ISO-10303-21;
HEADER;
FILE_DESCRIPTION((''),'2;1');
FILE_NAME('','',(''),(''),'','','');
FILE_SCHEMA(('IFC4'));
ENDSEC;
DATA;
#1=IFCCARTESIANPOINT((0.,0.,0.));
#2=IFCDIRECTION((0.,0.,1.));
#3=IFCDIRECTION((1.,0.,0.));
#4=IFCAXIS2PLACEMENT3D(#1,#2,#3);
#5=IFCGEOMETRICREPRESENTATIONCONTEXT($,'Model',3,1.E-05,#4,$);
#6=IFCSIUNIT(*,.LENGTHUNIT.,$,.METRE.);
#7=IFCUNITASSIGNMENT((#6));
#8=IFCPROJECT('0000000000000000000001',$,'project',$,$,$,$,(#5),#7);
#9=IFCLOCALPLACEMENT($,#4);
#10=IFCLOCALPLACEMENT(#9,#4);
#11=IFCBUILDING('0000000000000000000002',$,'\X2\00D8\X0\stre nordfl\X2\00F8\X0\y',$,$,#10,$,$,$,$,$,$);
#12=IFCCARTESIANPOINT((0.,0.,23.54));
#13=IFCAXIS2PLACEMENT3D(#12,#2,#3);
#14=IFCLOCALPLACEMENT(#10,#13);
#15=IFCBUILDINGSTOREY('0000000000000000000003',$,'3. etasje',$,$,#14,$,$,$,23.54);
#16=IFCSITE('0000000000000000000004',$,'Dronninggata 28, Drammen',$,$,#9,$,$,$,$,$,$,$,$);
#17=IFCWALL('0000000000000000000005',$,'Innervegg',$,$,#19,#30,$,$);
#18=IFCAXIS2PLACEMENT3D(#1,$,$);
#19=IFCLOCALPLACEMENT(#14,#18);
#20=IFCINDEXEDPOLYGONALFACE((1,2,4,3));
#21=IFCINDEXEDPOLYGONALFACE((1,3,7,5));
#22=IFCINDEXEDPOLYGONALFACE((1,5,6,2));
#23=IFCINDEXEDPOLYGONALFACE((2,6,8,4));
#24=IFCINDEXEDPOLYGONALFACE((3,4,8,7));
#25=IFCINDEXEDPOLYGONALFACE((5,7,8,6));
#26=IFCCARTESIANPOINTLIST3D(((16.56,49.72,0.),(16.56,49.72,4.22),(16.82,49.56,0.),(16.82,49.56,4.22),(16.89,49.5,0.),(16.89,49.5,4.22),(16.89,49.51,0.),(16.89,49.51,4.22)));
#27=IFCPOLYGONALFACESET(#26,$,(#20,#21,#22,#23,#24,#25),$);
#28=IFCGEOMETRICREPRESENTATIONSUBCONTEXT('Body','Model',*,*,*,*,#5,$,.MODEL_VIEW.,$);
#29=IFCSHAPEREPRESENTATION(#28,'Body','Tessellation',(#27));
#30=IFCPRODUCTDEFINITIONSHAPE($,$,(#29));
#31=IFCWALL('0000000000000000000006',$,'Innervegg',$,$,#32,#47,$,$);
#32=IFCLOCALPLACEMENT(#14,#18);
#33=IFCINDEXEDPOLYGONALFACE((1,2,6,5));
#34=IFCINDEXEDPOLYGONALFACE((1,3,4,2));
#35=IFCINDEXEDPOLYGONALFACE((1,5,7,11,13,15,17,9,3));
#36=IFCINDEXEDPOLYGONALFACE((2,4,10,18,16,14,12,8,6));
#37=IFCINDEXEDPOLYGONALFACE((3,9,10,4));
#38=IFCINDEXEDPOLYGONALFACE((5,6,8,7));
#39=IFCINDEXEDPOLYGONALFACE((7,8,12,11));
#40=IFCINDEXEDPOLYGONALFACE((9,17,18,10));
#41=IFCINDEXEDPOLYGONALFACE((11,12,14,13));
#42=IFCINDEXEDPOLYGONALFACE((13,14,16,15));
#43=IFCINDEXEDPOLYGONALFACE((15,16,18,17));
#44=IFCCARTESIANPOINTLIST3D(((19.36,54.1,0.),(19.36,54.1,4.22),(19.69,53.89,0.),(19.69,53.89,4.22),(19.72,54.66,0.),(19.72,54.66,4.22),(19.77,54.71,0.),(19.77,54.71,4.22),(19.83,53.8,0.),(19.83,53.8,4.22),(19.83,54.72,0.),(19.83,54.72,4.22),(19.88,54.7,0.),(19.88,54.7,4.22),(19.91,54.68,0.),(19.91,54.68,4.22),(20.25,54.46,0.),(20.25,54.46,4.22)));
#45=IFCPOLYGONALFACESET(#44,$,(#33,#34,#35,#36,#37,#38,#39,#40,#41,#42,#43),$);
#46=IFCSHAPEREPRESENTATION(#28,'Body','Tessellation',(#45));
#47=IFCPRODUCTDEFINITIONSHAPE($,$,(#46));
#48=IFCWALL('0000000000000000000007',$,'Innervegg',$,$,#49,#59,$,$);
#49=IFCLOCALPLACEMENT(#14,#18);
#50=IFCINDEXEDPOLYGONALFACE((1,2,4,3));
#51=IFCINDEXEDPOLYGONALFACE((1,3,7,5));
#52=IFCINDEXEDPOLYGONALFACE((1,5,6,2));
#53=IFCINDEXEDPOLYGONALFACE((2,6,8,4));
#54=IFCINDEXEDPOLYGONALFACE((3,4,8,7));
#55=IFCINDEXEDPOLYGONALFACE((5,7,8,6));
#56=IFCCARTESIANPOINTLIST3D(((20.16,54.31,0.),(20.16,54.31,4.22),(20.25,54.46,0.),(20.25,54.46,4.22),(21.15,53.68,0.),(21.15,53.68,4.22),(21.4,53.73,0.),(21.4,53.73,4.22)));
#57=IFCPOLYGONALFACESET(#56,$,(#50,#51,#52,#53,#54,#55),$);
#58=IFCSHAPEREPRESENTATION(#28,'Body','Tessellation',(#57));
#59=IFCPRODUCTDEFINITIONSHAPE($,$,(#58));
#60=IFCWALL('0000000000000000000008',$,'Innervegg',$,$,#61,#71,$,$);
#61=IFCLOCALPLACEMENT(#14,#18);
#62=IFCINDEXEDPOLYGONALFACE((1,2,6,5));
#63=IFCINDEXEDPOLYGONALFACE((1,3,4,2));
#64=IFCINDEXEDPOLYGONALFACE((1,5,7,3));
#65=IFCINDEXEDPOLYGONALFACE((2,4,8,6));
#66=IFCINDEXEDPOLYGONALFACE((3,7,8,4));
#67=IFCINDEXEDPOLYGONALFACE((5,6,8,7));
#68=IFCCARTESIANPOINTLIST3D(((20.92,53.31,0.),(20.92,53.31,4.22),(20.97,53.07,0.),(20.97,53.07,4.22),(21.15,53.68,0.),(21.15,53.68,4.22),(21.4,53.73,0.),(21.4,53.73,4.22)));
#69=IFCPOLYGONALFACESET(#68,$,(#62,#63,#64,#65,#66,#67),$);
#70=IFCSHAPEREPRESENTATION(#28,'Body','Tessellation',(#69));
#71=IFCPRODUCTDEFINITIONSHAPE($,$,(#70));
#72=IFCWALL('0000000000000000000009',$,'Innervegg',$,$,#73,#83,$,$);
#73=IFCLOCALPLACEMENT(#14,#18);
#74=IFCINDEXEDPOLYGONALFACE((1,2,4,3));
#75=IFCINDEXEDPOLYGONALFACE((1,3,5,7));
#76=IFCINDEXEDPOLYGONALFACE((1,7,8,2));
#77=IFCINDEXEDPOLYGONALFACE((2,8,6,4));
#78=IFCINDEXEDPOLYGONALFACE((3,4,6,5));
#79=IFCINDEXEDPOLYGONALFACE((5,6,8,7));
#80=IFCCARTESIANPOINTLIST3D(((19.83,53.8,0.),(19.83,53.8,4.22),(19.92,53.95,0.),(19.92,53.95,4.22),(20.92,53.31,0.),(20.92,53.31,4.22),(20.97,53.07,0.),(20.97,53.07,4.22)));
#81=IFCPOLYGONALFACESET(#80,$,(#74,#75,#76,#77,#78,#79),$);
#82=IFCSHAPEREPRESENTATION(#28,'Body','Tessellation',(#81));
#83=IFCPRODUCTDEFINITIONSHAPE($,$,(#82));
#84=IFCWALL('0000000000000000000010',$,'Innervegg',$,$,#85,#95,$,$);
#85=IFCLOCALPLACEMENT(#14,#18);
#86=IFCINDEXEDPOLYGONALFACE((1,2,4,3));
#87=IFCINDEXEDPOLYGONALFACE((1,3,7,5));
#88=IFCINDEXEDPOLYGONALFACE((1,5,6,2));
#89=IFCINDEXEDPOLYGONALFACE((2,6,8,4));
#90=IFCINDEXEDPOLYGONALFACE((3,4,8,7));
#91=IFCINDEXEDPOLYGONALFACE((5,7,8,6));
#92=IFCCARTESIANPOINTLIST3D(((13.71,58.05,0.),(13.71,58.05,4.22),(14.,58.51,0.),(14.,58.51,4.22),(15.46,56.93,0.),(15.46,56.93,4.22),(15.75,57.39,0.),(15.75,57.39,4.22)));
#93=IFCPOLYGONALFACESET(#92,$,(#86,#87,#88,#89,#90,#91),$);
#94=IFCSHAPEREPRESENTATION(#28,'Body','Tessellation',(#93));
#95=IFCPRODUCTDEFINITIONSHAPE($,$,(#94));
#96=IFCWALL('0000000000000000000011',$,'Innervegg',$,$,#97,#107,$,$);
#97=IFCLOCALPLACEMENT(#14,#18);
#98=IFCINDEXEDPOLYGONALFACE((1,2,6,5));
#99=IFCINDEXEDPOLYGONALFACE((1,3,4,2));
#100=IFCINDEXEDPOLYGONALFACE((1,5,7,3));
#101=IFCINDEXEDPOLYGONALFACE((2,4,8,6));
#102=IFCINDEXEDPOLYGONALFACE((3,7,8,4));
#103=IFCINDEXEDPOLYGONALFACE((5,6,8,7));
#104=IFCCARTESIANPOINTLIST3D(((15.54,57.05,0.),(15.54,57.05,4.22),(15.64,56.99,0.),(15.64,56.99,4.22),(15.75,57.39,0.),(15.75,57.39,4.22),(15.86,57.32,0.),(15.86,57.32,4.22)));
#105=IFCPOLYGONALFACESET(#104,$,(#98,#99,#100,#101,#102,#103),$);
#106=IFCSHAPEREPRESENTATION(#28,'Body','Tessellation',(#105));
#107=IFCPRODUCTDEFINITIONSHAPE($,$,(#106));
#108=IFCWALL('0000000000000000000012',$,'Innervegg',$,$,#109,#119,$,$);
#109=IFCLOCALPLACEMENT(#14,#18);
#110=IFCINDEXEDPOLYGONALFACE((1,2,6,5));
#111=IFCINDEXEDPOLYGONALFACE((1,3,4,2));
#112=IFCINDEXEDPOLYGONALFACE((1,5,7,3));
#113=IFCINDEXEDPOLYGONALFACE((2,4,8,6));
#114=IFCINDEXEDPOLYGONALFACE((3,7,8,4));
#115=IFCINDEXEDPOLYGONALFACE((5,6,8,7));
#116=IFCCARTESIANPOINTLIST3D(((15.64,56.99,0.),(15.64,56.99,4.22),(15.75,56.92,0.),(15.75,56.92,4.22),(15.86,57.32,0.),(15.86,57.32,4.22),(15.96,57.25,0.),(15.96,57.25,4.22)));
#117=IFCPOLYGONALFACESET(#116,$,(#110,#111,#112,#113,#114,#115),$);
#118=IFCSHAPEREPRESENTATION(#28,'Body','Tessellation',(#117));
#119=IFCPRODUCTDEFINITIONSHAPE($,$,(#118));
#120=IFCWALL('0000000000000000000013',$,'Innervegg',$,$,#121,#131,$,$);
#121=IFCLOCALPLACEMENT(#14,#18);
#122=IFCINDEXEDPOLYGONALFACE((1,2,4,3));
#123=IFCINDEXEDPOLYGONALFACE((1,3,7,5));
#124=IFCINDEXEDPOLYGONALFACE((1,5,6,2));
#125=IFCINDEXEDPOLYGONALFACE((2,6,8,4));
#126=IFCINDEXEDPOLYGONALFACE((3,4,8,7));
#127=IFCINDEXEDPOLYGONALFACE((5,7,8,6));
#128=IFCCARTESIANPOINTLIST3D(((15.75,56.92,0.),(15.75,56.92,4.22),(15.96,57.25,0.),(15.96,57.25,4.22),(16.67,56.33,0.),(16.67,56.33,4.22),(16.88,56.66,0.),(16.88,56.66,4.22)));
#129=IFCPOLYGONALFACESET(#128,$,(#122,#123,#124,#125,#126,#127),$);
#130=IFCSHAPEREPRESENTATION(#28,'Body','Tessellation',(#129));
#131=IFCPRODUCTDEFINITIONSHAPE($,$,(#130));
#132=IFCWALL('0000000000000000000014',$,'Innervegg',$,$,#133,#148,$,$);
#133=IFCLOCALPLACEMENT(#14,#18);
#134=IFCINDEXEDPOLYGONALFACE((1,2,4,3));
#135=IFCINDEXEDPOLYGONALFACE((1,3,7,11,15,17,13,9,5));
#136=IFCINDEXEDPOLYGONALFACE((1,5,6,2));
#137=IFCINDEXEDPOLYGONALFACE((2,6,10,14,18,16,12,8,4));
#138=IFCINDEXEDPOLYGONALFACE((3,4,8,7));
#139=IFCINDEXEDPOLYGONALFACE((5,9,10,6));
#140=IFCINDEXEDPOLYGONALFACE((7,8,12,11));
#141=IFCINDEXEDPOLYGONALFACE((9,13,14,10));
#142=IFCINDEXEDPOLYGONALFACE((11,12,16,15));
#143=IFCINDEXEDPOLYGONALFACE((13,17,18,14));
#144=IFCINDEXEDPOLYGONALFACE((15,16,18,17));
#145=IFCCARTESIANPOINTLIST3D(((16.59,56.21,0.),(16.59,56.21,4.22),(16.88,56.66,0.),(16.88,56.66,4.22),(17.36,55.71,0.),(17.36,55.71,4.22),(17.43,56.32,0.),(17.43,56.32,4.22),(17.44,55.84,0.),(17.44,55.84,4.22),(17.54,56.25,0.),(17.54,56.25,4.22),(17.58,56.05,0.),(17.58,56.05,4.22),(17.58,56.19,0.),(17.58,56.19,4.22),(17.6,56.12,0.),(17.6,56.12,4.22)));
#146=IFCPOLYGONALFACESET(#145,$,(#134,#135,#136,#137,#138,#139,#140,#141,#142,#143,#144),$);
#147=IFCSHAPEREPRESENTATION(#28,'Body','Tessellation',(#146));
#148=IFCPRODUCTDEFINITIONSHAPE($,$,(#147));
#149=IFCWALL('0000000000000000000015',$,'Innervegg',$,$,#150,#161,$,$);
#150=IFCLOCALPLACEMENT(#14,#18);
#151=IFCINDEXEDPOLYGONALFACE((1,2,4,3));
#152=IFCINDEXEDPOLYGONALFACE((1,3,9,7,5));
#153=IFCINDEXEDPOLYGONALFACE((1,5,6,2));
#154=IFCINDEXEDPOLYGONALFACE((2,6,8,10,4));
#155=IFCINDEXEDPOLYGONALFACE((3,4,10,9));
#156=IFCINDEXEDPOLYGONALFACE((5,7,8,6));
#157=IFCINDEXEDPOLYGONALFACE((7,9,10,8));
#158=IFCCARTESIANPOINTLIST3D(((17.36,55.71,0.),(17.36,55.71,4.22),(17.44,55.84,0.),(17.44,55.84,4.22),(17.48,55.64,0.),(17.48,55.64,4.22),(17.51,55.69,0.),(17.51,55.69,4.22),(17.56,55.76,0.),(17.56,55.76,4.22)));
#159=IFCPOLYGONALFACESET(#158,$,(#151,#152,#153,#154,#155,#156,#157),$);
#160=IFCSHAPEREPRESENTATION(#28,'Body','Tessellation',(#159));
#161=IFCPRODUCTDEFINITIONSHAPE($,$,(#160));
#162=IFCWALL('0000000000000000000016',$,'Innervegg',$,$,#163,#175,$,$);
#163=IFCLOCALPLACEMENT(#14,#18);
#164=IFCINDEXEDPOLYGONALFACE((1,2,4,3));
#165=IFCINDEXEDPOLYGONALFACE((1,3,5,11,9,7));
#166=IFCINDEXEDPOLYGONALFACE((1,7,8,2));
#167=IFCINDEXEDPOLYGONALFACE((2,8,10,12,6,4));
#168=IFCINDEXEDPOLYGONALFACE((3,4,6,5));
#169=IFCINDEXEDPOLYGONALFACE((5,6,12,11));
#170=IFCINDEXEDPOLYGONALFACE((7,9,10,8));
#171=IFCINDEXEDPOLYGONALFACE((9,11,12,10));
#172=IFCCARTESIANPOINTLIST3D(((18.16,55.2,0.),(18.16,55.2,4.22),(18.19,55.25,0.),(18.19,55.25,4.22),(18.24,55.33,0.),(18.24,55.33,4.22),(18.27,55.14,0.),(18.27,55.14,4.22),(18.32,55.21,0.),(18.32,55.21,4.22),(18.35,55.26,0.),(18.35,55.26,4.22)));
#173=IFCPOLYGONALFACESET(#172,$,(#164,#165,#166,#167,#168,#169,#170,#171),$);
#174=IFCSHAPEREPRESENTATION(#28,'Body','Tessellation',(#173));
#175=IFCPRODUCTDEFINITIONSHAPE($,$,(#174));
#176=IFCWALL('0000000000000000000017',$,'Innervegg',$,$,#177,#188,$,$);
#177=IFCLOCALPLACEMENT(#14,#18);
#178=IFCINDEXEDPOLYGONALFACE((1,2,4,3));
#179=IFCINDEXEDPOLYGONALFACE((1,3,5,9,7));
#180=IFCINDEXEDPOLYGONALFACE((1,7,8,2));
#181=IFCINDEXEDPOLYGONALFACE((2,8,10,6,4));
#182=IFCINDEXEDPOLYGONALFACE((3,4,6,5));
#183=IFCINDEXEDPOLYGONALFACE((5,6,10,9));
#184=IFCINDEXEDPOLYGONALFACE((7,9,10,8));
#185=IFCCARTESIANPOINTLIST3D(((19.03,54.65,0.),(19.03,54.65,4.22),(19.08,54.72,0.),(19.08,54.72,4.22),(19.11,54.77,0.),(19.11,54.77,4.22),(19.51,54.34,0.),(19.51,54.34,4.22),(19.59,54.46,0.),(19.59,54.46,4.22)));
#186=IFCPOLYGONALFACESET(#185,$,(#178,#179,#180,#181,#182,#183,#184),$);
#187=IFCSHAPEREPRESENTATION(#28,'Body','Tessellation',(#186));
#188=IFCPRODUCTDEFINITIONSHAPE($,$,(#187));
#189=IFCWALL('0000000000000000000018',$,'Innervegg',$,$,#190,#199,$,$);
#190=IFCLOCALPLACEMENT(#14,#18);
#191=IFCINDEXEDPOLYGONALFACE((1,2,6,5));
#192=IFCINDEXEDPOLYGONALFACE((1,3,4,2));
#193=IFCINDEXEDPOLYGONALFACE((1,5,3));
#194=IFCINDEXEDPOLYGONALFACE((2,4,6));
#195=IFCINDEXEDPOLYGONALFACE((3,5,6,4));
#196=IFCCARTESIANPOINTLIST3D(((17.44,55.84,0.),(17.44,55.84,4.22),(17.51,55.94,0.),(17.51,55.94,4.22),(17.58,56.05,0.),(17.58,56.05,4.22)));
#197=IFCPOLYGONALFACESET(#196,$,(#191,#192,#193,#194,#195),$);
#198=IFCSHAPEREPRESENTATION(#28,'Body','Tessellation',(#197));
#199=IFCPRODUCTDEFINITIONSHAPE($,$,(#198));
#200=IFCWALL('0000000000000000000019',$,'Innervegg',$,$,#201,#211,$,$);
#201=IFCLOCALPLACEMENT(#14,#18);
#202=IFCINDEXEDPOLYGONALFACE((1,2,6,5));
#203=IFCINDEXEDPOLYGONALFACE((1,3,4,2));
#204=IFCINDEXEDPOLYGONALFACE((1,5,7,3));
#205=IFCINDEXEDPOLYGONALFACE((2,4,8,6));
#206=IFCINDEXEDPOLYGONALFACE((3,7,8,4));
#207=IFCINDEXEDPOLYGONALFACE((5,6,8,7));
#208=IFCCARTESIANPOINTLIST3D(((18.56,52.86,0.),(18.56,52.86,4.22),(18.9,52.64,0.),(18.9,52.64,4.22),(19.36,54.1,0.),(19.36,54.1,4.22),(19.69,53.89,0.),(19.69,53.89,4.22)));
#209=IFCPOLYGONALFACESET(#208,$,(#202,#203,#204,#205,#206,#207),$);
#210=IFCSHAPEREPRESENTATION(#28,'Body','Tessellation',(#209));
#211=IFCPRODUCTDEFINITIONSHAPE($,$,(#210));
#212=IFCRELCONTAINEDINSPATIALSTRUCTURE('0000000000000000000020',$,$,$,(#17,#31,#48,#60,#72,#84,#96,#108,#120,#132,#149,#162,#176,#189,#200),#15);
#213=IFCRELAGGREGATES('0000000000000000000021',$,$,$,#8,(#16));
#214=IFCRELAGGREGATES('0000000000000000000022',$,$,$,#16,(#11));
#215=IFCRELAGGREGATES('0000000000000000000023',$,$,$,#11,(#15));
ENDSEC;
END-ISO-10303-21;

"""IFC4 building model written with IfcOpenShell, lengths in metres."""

from ifc_helpers import new_model, si_unit, frame, origin_with_axes, place, context, subcontext, project, spatial, polyline, outline, extrude, element, save


model = new_model("IFC4")

# Units and contexts
model_context = context("Model", 3, precision=1e-05, world=origin_with_axes())
body_context = subcontext(model_context, "Body", "Model", "MODEL_VIEW")
ifc_project = project(units=[si_unit("LENGTHUNIT", "METRE")], contexts=[model_context])

# Site, building, storey
site_placement = place(None, origin_with_axes())
site = spatial("IfcSite", under=ifc_project, at=site_placement, Name="Dronninggata 28, Drammen")
building_placement = place(site_placement, origin_with_axes())
building = spatial("IfcBuilding", under=site, at=building_placement, Name="Østre nordfløy")
storey_placement = place(building_placement, frame((0.0, 0.0, 23.54), z_axis=(0.0, 0.0, 1.0), x_axis=(1.0, 0.0, 0.0)))
storey = spatial("IfcBuildingStorey", under=building, at=storey_placement, Name="3. etasje", Elevation=23.54)

# Walls
wall_1_placement = place(storey_placement, frame((0.0, 0.0, -23.54), z_axis=(0.0, 0.0, 1.0), x_axis=(1.0, 0.0, 0.0)))
element("IfcWall", 1, at=wall_1_placement, inside=storey, Name="Innervegg", context=body_context, shape_type="SweptSolid", body=[
    extrude(outline(polyline([(16.82, 49.56), (16.56, 49.72), (16.56, 49.72), (16.89, 49.5), (16.89, 49.51), (16.82, 49.56)])), frame((0.0, 0.0, 23.54)), (0.0, 0.0, 1.0), 4.22),
])
wall_2_placement = place(storey_placement, frame((0.0, 0.0, -23.54), z_axis=(0.0, 0.0, 1.0), x_axis=(1.0, 0.0, 0.0)))
element("IfcWall", 2, at=wall_2_placement, inside=storey, Name="Innervegg", context=body_context, shape_type="SweptSolid", body=[
    extrude(outline(polyline([(19.69, 53.89), (19.36, 54.1), (19.72, 54.66), (19.77, 54.71), (19.83, 54.72), (19.88, 54.7), (19.91, 54.68), (20.25, 54.46), (19.83, 53.8), (19.69, 53.89)])), frame((0.0, 0.0, 23.54)), (0.0, 0.0, 1.0), 4.22),
])
wall_3_placement = place(storey_placement, frame((0.0, 0.0, -23.54), z_axis=(0.0, 0.0, 1.0), x_axis=(1.0, 0.0, 0.0)))
element("IfcWall", 3, at=wall_3_placement, inside=storey, Name="Innervegg", context=body_context, shape_type="SweptSolid", body=[
    extrude(outline(polyline([(20.16, 54.31), (20.25, 54.46), (21.4, 53.73), (21.15, 53.68), (20.16, 54.31)])), frame((0.0, 0.0, 23.54)), (0.0, 0.0, 1.0), 4.22),
])
wall_4_placement = place(storey_placement, frame((0.0, 0.0, -23.54), z_axis=(0.0, 0.0, 1.0), x_axis=(1.0, 0.0, 0.0)))
element("IfcWall", 4, at=wall_4_placement, inside=storey, Name="Innervegg", context=body_context, shape_type="SweptSolid", body=[
    extrude(outline(polyline([(21.15, 53.68), (21.4, 53.73), (20.97, 53.07), (20.92, 53.31), (21.15, 53.68)])), frame((0.0, 0.0, 23.54)), (0.0, 0.0, 1.0), 4.22),
])
wall_5_placement = place(storey_placement, frame((0.0, 0.0, -23.54), z_axis=(0.0, 0.0, 1.0), x_axis=(1.0, 0.0, 0.0)))
element("IfcWall", 5, at=wall_5_placement, inside=storey, Name="Innervegg", context=body_context, shape_type="SweptSolid", body=[
    extrude(outline(polyline([(20.92, 53.31), (20.97, 53.07), (19.83, 53.8), (19.92, 53.95), (20.92, 53.31)])), frame((0.0, 0.0, 23.54)), (0.0, 0.0, 1.0), 4.22),
])
wall_6_placement = place(storey_placement, frame((0.0, 0.0, -23.54), z_axis=(0.0, 0.0, 1.0), x_axis=(1.0, 0.0, 0.0)))
element("IfcWall", 6, at=wall_6_placement, inside=storey, Name="Innervegg", context=body_context, shape_type="SweptSolid", body=[
    extrude(outline(polyline([(14.0, 58.51), (15.75, 57.39), (15.46, 56.93), (13.71, 58.05), (14.0, 58.51)])), frame((0.0, 0.0, 23.54)), (0.0, 0.0, 1.0), 4.22),
])
wall_7_placement = place(storey_placement, frame((0.0, 0.0, -23.54), z_axis=(0.0, 0.0, 1.0), x_axis=(1.0, 0.0, 0.0)))
element("IfcWall", 7, at=wall_7_placement, inside=storey, Name="Innervegg", context=body_context, shape_type="SweptSolid", body=[
    extrude(outline(polyline([(15.64, 56.99), (15.54, 57.05), (15.75, 57.39), (15.86, 57.32), (15.64, 56.99)])), frame((0.0, 0.0, 23.54)), (0.0, 0.0, 1.0), 4.22),
])
wall_8_placement = place(storey_placement, frame((0.0, 0.0, -23.54), z_axis=(0.0, 0.0, 1.0), x_axis=(1.0, 0.0, 0.0)))
element("IfcWall", 8, at=wall_8_placement, inside=storey, Name="Innervegg", context=body_context, shape_type="SweptSolid", body=[
    extrude(outline(polyline([(15.75, 56.92), (15.64, 56.99), (15.86, 57.32), (15.96, 57.25), (15.75, 56.92)])), frame((0.0, 0.0, 23.54)), (0.0, 0.0, 1.0), 4.22),
])
wall_9_placement = place(storey_placement, frame((0.0, 0.0, -23.54), z_axis=(0.0, 0.0, 1.0), x_axis=(1.0, 0.0, 0.0)))
element("IfcWall", 9, at=wall_9_placement, inside=storey, Name="Innervegg", context=body_context, shape_type="SweptSolid", body=[
    extrude(outline(polyline([(15.96, 57.25), (16.88, 56.66), (16.67, 56.33), (15.75, 56.92), (15.96, 57.25)])), frame((0.0, 0.0, 23.54)), (0.0, 0.0, 1.0), 4.22),
])
wall_10_placement = place(storey_placement, frame((0.0, 0.0, -23.54), z_axis=(0.0, 0.0, 1.0), x_axis=(1.0, 0.0, 0.0)))
element("IfcWall", 10, at=wall_10_placement, inside=storey, Name="Innervegg", context=body_context, shape_type="SweptSolid", body=[
    extrude(outline(polyline([(16.59, 56.21), (16.88, 56.66), (17.43, 56.32), (17.54, 56.25), (17.58, 56.19), (17.6, 56.12), (17.58, 56.05), (17.44, 55.84), (17.36, 55.71), (16.59, 56.21)])), frame((0.0, 0.0, 23.54)), (0.0, 0.0, 1.0), 4.22),
])
wall_11_placement = place(storey_placement, frame((0.0, 0.0, -23.54), z_axis=(0.0, 0.0, 1.0), x_axis=(1.0, 0.0, 0.0)))
element("IfcWall", 11, at=wall_11_placement, inside=storey, Name="Innervegg", context=body_context, shape_type="SweptSolid", body=[
    extrude(outline(polyline([(17.36, 55.71), (17.44, 55.84), (17.56, 55.76), (17.51, 55.69), (17.48, 55.64), (17.36, 55.71)])), frame((0.0, 0.0, 23.54)), (0.0, 0.0, 1.0), 4.22),
])
wall_12_placement = place(storey_placement, frame((0.0, 0.0, -23.54), z_axis=(0.0, 0.0, 1.0), x_axis=(1.0, 0.0, 0.0)))
element("IfcWall", 12, at=wall_12_placement, inside=storey, Name="Innervegg", context=body_context, shape_type="SweptSolid", body=[
    extrude(outline(polyline([(18.24, 55.33), (18.35, 55.26), (18.32, 55.21), (18.27, 55.14), (18.16, 55.2), (18.19, 55.25), (18.24, 55.33)])), frame((0.0, 0.0, 23.54)), (0.0, 0.0, 1.0), 4.22),
])
wall_13_placement = place(storey_placement, frame((0.0, 0.0, -23.54), z_axis=(0.0, 0.0, 1.0), x_axis=(1.0, 0.0, 0.0)))
element("IfcWall", 13, at=wall_13_placement, inside=storey, Name="Innervegg", context=body_context, shape_type="SweptSolid", body=[
    extrude(outline(polyline([(19.59, 54.46), (19.51, 54.34), (19.03, 54.65), (19.08, 54.72), (19.11, 54.77), (19.59, 54.46)])), frame((0.0, 0.0, 23.54)), (0.0, 0.0, 1.0), 4.22),
])
wall_14_placement = place(storey_placement, frame((0.0, 0.0, -23.54), z_axis=(0.0, 0.0, 1.0), x_axis=(1.0, 0.0, 0.0)))
element("IfcWall", 14, at=wall_14_placement, inside=storey, Name="Innervegg", context=body_context, shape_type="SweptSolid", body=[
    extrude(outline(polyline([(17.51, 55.94), (17.44, 55.84), (17.58, 56.05), (17.58, 56.05), (17.51, 55.94)])), frame((0.0, 0.0, 23.54)), (0.0, 0.0, 1.0), 4.22),
])
wall_15_placement = place(storey_placement, frame((0.0, 0.0, -23.54), z_axis=(0.0, 0.0, 1.0), x_axis=(1.0, 0.0, 0.0)))
element("IfcWall", 15, at=wall_15_placement, inside=storey, Name="Innervegg", context=body_context, shape_type="SweptSolid", body=[
    extrude(outline(polyline([(18.9, 52.64), (18.56, 52.86), (19.36, 54.1), (19.69, 53.89), (18.9, 52.64)])), frame((0.0, 0.0, 23.54)), (0.0, 0.0, 1.0), 4.22),
])

save(model, "model.ifc")
